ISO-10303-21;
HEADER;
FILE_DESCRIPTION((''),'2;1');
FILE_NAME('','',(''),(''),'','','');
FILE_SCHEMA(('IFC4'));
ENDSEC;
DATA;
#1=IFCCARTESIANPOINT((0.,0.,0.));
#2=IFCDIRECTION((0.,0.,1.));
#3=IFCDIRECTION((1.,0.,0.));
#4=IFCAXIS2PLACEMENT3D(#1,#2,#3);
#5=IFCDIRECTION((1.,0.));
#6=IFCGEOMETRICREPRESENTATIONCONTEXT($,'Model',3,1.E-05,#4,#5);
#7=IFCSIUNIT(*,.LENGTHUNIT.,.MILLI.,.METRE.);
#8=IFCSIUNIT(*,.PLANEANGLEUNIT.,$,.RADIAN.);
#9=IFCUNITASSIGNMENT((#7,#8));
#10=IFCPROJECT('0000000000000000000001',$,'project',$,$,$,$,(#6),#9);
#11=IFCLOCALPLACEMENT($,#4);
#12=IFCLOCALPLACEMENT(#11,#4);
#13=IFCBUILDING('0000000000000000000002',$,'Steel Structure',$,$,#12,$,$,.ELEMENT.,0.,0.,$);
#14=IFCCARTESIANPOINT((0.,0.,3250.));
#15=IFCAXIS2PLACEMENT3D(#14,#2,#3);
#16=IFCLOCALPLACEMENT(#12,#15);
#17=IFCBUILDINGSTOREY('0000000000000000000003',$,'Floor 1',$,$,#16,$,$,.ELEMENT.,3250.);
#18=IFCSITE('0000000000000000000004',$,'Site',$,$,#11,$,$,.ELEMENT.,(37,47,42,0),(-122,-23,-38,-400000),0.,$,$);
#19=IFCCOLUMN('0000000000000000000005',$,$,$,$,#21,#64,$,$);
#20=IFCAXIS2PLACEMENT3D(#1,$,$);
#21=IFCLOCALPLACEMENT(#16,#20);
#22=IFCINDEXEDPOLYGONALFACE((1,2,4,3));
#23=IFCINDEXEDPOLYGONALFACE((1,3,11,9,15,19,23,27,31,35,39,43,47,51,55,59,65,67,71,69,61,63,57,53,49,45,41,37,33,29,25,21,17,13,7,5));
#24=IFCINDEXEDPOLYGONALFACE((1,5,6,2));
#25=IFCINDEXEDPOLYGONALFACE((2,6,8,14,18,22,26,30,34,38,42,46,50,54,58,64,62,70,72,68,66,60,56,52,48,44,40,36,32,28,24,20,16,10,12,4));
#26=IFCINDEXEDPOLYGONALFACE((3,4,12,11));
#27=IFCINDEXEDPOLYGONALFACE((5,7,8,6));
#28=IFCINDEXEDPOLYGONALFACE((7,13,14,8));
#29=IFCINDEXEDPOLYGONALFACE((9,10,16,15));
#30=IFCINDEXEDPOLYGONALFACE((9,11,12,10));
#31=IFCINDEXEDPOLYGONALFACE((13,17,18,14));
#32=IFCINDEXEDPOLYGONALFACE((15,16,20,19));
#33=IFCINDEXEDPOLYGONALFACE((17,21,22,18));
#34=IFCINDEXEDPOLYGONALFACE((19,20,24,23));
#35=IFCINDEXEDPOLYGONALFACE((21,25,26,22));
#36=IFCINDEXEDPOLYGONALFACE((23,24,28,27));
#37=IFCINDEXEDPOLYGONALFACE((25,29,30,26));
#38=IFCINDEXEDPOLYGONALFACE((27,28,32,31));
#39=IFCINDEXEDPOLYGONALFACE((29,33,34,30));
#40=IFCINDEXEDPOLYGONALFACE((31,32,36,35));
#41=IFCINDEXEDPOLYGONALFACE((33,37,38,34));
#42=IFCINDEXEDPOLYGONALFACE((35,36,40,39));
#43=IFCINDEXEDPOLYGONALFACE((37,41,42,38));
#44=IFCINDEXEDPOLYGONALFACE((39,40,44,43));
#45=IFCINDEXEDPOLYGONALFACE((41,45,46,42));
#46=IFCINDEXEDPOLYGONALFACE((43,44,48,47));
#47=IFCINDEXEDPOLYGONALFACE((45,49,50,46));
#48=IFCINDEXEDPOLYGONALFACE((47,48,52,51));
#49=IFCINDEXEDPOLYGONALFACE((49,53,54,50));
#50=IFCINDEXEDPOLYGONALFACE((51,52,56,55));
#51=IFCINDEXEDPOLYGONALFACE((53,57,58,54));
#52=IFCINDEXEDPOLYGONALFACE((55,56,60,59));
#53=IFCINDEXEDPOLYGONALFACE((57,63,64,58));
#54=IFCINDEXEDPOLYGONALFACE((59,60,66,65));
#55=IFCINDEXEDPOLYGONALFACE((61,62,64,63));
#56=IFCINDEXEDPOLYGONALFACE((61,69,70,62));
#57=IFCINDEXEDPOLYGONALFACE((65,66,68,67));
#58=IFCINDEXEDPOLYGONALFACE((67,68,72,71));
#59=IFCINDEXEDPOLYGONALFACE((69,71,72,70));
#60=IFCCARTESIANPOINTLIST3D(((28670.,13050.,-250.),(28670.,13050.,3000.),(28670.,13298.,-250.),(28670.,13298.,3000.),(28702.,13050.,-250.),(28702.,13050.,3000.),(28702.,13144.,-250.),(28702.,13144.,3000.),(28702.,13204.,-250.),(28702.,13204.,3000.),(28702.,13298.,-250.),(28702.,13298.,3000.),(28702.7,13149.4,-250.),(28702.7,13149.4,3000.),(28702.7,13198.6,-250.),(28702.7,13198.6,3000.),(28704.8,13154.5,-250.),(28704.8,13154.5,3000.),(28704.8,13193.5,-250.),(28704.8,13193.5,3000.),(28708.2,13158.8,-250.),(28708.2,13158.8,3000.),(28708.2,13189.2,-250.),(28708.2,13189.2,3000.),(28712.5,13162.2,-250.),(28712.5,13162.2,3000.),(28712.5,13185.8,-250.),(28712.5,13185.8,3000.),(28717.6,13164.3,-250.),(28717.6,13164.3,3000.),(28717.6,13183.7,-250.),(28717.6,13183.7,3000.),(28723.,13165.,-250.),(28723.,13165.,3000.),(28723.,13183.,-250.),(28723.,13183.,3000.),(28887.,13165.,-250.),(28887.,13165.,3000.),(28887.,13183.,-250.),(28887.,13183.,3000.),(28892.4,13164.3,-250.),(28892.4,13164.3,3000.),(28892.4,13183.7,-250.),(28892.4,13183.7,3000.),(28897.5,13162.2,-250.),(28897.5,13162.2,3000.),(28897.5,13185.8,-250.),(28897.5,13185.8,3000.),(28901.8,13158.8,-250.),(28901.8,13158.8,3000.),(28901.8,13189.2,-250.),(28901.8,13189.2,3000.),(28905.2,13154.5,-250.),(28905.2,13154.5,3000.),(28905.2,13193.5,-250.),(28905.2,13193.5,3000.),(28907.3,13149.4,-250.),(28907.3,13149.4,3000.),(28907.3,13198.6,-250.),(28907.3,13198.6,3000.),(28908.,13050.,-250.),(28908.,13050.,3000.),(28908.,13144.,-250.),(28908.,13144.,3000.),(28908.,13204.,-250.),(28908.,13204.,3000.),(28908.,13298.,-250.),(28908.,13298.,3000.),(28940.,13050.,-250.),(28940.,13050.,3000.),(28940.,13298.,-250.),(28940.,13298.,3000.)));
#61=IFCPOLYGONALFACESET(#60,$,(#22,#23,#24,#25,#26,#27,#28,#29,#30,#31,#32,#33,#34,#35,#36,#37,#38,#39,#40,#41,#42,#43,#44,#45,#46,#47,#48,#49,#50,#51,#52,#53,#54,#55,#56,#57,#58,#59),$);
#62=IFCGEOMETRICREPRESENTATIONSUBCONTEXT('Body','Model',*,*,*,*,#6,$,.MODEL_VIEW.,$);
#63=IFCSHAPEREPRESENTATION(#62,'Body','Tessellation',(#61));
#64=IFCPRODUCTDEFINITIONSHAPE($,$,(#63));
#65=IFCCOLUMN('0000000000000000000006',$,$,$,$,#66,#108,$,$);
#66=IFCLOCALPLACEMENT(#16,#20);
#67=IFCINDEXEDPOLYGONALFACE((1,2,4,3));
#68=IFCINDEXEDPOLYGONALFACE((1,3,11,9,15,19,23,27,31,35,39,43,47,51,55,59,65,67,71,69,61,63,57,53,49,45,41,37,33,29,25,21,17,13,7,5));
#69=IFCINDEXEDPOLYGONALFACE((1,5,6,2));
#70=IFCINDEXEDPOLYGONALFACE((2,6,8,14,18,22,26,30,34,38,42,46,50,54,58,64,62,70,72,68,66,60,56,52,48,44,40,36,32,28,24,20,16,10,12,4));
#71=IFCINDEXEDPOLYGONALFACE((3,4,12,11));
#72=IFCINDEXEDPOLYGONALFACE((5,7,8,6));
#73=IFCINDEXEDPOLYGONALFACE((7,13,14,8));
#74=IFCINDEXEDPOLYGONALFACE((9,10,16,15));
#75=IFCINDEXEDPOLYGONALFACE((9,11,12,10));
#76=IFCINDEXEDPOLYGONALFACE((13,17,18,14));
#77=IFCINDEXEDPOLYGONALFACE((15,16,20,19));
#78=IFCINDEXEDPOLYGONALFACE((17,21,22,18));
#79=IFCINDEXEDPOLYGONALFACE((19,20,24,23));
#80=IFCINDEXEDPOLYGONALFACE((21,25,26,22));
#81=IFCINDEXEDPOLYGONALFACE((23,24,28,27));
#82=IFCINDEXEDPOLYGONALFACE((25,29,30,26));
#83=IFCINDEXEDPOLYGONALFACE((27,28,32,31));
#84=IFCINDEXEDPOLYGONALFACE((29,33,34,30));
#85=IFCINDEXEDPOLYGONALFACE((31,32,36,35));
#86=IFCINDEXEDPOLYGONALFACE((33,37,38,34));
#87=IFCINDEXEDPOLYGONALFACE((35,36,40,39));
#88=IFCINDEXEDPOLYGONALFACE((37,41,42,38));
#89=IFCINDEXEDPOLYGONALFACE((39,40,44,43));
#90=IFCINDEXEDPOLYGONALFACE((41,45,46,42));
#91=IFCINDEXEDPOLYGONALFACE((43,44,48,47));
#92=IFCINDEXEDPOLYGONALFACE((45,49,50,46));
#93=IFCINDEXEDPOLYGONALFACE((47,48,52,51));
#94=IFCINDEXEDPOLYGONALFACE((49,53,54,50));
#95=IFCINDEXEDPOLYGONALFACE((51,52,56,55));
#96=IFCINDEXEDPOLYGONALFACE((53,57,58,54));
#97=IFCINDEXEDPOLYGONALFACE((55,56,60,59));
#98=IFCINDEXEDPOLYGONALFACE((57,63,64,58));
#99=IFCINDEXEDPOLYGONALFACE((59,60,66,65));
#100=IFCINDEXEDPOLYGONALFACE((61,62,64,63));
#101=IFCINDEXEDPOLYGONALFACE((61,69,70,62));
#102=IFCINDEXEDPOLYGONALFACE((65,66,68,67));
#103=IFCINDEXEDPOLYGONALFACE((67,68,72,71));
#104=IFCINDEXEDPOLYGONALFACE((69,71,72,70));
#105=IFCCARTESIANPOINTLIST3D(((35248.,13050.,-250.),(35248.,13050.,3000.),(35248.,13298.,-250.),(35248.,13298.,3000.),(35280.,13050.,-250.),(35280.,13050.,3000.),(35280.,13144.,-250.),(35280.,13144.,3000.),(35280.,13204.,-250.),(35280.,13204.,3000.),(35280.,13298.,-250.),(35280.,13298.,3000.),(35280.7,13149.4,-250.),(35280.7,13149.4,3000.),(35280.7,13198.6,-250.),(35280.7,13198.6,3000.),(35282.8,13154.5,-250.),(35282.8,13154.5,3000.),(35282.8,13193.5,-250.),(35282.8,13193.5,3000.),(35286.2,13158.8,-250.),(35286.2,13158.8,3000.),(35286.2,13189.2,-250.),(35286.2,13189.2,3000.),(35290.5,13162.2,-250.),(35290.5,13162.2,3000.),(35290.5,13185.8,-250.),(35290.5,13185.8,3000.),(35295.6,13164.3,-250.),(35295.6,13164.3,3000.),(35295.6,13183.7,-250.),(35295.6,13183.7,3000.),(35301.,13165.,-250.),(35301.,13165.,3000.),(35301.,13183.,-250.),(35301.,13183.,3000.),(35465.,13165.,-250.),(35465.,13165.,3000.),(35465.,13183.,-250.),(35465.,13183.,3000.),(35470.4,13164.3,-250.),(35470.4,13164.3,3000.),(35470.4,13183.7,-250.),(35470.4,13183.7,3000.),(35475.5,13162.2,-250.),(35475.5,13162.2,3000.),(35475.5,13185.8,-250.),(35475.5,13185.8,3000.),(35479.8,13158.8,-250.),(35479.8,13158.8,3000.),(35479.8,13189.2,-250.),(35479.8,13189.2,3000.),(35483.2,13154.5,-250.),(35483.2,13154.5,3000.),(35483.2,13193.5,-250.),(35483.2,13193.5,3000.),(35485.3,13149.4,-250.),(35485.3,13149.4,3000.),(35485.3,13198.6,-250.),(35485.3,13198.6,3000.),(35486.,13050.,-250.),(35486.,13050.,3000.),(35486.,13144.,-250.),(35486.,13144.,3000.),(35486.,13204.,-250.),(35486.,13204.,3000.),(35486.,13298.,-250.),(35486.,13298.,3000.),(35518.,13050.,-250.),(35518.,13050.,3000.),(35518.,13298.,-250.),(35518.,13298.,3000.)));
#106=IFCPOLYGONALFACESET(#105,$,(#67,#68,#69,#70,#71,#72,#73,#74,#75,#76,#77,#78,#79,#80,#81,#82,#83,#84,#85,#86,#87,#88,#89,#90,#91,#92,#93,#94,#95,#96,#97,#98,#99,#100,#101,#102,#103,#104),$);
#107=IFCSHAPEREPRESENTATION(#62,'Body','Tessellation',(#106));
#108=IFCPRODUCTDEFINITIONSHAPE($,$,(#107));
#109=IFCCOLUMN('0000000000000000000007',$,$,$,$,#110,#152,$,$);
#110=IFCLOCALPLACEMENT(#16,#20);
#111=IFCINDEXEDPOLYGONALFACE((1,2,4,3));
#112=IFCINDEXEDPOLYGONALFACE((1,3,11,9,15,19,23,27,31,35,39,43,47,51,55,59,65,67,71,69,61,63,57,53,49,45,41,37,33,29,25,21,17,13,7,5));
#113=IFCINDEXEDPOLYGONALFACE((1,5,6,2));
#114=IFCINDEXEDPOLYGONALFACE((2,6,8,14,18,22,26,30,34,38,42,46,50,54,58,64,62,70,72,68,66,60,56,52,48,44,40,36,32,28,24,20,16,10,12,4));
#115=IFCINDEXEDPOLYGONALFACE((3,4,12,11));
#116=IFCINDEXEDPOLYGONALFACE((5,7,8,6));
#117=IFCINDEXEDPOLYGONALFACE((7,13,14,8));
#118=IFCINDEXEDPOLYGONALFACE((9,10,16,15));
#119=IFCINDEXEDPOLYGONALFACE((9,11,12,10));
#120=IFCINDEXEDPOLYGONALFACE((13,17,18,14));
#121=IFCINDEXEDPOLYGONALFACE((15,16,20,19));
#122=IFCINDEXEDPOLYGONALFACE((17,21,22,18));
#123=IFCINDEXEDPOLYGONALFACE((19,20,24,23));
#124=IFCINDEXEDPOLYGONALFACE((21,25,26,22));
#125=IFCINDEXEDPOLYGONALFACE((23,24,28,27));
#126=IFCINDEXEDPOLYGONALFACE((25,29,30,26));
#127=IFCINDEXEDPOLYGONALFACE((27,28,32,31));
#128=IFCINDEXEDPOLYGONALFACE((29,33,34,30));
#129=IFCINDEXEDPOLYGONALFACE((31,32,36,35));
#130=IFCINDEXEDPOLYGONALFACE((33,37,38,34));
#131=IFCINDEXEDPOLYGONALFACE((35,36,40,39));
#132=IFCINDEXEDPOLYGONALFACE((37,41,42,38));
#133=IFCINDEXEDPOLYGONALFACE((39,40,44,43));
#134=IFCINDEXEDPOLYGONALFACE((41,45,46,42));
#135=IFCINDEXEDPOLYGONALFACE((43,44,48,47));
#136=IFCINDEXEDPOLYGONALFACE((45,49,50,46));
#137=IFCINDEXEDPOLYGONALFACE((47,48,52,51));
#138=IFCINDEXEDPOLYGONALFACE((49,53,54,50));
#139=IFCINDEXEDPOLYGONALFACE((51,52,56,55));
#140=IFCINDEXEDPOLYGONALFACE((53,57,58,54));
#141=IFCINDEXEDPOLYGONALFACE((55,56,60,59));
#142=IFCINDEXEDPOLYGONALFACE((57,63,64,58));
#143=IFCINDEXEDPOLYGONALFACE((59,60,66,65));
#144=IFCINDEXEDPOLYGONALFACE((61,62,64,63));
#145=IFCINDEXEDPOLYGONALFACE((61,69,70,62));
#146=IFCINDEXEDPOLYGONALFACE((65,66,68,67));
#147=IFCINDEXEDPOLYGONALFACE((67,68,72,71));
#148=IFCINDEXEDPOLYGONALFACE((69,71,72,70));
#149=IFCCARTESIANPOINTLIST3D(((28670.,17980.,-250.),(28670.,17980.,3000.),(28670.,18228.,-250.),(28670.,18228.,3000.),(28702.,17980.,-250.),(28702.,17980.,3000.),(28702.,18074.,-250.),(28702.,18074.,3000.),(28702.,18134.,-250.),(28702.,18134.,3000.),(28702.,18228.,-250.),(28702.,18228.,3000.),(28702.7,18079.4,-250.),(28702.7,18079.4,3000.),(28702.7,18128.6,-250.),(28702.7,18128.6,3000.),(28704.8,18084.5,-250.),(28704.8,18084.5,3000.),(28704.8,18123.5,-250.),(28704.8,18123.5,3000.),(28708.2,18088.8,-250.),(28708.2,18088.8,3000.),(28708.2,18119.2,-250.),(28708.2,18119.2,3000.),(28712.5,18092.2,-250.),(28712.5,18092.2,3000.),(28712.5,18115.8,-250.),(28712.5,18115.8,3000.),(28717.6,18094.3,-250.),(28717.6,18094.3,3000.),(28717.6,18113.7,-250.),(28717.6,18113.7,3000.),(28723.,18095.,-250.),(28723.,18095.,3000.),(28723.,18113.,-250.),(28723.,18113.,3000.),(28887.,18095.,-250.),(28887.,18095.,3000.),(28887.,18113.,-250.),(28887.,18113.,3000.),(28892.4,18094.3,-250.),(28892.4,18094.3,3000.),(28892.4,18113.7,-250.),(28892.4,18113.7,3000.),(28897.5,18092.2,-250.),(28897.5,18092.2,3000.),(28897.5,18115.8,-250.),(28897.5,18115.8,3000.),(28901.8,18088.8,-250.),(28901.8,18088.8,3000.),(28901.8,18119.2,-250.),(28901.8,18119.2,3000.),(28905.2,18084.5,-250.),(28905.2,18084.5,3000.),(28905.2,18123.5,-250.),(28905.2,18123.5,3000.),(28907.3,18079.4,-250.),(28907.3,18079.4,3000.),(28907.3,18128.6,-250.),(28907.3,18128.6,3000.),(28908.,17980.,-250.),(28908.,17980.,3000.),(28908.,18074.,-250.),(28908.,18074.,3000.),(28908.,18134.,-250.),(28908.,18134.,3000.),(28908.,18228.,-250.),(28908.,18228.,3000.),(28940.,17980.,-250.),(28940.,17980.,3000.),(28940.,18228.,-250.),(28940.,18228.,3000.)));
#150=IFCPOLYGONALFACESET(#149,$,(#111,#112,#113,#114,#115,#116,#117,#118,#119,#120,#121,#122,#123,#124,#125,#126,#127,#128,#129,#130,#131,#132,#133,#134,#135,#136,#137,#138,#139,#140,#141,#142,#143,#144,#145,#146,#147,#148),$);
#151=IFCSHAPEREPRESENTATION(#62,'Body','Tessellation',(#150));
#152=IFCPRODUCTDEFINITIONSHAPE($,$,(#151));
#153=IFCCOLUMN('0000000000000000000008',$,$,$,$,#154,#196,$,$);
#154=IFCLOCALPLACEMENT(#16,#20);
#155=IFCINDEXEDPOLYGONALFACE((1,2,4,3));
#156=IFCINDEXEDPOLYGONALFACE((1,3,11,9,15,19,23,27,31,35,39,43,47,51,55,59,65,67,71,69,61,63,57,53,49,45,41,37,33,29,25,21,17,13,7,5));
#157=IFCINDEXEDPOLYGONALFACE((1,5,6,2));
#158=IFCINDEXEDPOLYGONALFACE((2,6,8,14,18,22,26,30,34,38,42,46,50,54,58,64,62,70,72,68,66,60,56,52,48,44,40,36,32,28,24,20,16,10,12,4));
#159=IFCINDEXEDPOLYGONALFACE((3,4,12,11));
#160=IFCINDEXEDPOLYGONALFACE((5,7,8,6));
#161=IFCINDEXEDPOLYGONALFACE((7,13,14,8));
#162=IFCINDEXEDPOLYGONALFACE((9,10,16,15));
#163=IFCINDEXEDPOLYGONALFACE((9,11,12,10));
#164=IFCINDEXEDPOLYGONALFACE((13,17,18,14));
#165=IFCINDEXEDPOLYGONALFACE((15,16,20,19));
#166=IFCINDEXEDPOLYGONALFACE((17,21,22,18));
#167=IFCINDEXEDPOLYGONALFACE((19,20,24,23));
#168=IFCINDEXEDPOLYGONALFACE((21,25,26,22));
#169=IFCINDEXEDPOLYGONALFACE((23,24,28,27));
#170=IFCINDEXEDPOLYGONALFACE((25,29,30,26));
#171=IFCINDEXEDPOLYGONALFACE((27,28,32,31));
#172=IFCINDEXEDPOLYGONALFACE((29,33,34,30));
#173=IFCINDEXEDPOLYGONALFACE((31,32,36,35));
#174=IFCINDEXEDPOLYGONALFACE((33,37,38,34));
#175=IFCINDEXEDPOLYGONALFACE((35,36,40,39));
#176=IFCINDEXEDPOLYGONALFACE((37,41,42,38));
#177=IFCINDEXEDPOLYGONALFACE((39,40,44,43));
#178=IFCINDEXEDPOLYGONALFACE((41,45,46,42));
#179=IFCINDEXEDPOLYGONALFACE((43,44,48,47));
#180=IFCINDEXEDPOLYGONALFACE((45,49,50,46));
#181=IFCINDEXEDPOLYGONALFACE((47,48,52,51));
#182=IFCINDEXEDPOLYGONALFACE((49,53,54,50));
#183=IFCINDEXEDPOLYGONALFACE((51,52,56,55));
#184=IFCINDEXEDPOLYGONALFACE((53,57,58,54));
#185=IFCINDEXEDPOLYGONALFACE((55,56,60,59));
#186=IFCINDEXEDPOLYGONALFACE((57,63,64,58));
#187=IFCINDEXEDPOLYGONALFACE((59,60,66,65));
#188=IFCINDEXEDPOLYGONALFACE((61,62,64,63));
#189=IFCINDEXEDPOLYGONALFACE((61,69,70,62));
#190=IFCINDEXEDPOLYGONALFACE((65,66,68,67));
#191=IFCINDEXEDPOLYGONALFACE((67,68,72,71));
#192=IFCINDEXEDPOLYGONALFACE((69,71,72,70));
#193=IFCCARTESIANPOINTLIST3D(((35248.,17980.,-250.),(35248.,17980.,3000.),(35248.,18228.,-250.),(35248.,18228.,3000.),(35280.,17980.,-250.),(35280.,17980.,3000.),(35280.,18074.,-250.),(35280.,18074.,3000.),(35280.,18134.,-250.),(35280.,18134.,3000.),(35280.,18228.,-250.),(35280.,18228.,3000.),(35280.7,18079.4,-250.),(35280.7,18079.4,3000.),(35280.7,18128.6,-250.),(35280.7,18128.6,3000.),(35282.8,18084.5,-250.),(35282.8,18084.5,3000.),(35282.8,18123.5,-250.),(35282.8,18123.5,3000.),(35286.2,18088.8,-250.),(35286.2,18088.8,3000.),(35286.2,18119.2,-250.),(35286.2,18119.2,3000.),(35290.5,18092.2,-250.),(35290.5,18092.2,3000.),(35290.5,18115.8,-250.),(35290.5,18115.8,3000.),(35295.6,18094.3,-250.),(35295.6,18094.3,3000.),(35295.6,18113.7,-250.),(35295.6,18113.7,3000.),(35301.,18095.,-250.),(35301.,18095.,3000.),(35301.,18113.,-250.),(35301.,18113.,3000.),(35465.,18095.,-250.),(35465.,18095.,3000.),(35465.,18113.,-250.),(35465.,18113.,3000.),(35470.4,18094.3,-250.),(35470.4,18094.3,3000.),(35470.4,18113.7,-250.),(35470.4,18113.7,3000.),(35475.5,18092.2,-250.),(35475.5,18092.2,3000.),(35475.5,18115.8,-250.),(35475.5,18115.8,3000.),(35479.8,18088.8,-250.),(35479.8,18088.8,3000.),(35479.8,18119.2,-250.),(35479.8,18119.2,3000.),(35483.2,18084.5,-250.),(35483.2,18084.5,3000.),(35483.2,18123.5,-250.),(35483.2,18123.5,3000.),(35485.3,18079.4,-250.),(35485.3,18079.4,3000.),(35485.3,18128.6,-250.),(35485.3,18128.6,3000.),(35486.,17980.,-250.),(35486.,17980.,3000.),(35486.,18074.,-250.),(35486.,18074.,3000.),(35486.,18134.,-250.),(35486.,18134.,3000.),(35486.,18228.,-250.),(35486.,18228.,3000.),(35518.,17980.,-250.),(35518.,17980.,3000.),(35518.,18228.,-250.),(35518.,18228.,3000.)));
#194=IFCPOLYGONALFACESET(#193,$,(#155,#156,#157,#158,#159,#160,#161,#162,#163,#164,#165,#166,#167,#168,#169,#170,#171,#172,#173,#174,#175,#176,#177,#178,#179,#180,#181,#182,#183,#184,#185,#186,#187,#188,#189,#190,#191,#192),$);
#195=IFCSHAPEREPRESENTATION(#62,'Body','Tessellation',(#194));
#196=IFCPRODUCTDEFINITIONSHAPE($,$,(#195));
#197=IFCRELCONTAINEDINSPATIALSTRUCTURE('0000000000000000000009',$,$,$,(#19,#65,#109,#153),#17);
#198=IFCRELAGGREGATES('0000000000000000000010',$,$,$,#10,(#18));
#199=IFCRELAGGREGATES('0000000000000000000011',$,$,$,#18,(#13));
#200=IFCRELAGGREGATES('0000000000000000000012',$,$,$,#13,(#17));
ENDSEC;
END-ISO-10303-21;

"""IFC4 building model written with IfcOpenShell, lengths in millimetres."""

from ifc_helpers import new_model, si_unit, direction, frame, origin_with_axes, origin_2d_with_axis, place, context, subcontext, project, spatial, i_section, extrude, element, save


model = new_model("IFC4")

# Units and contexts
model_context = context("Model", 3, precision=1e-05, world=origin_with_axes(), true_north=direction((1.0, 0.0)))
body_context = subcontext(model_context, "Body", "Model", "MODEL_VIEW")
ifc_project = project(units=[si_unit("LENGTHUNIT", "METRE", prefix="MILLI"), si_unit("PLANEANGLEUNIT", "RADIAN")], contexts=[model_context])

# Site, building, storey
site_placement = place(None, origin_with_axes())
site = spatial("IfcSite", under=ifc_project, at=site_placement, Name="Site", CompositionType="ELEMENT", RefLatitude=(37, 47, 42, 0), RefLongitude=(-122, -23, -38, -400000), RefElevation=0.0)
building_placement = place(site_placement, origin_with_axes())
building = spatial("IfcBuilding", under=site, at=building_placement, Name="Steel Structure", CompositionType="ELEMENT", ElevationOfRefHeight=0.0, ElevationOfTerrain=0.0)
storey_placement = place(building_placement, frame((0.0, 0.0, 3250.0), z_axis=(0.0, 0.0, 1.0), x_axis=(1.0, 0.0, 0.0)))
storey = spatial("IfcBuildingStorey", under=building, at=storey_placement, Name="Floor 1", CompositionType="ELEMENT", Elevation=3250.0)

# Columns
for number, where, z_axis, x_axis in (
    (1, (28805.0, 13174.0, -250.0), (0.0, 0.0, 1.0), (0.0, -1.0, 0.0)),
    (2, (35383.0, 13174.0, -250.0), (0.0, 0.0, 1.0), (0.0, -1.0, 0.0)),
):
    element("IfcColumn", number, at=place(storey_placement, frame(where, z_axis=z_axis, x_axis=x_axis)), inside=storey, context=body_context, shape_type="SweptSolid", body=[
        extrude(i_section(OverallWidth=248.0, OverallDepth=270.0, WebThickness=18.0, FlangeThickness=32.0, FilletRadius=21.0, at=origin_2d_with_axis()), origin_with_axes(), (0.0, 0.0, 1.0), 3250.0),
    ])
column_1_placement = place(storey_placement, frame((28805.0, 18104.0, -250.0), z_axis=(0.0, 0.0, 1.0), x_axis=(0.0, -1.0, 0.0)))
element("IfcColumn", 3, at=column_1_placement, inside=storey, context=body_context, shape_type="SweptSolid", body=[
    extrude(i_section(OverallWidth=248.0, OverallDepth=270.0, WebThickness=18.0, FlangeThickness=32.0, FilletRadius=21.0, at=origin_2d_with_axis()), origin_with_axes(), (0.0, 0.0, 1.0), 3250.0),
])
column_2_placement = place(storey_placement, frame((35383.0, 18104.0, -250.0), z_axis=(0.0, 0.0, 1.0), x_axis=(0.0, -1.0, 0.0)))
element("IfcColumn", 4, at=column_2_placement, inside=storey, context=body_context, shape_type="SweptSolid", body=[
    extrude(i_section(OverallWidth=248.0, OverallDepth=270.0, WebThickness=18.0, FlangeThickness=32.0, FilletRadius=21.0, at=origin_2d_with_axis()), origin_with_axes(), (0.0, 0.0, 1.0), 3250.0),
])

save(model, "model.ifc")
